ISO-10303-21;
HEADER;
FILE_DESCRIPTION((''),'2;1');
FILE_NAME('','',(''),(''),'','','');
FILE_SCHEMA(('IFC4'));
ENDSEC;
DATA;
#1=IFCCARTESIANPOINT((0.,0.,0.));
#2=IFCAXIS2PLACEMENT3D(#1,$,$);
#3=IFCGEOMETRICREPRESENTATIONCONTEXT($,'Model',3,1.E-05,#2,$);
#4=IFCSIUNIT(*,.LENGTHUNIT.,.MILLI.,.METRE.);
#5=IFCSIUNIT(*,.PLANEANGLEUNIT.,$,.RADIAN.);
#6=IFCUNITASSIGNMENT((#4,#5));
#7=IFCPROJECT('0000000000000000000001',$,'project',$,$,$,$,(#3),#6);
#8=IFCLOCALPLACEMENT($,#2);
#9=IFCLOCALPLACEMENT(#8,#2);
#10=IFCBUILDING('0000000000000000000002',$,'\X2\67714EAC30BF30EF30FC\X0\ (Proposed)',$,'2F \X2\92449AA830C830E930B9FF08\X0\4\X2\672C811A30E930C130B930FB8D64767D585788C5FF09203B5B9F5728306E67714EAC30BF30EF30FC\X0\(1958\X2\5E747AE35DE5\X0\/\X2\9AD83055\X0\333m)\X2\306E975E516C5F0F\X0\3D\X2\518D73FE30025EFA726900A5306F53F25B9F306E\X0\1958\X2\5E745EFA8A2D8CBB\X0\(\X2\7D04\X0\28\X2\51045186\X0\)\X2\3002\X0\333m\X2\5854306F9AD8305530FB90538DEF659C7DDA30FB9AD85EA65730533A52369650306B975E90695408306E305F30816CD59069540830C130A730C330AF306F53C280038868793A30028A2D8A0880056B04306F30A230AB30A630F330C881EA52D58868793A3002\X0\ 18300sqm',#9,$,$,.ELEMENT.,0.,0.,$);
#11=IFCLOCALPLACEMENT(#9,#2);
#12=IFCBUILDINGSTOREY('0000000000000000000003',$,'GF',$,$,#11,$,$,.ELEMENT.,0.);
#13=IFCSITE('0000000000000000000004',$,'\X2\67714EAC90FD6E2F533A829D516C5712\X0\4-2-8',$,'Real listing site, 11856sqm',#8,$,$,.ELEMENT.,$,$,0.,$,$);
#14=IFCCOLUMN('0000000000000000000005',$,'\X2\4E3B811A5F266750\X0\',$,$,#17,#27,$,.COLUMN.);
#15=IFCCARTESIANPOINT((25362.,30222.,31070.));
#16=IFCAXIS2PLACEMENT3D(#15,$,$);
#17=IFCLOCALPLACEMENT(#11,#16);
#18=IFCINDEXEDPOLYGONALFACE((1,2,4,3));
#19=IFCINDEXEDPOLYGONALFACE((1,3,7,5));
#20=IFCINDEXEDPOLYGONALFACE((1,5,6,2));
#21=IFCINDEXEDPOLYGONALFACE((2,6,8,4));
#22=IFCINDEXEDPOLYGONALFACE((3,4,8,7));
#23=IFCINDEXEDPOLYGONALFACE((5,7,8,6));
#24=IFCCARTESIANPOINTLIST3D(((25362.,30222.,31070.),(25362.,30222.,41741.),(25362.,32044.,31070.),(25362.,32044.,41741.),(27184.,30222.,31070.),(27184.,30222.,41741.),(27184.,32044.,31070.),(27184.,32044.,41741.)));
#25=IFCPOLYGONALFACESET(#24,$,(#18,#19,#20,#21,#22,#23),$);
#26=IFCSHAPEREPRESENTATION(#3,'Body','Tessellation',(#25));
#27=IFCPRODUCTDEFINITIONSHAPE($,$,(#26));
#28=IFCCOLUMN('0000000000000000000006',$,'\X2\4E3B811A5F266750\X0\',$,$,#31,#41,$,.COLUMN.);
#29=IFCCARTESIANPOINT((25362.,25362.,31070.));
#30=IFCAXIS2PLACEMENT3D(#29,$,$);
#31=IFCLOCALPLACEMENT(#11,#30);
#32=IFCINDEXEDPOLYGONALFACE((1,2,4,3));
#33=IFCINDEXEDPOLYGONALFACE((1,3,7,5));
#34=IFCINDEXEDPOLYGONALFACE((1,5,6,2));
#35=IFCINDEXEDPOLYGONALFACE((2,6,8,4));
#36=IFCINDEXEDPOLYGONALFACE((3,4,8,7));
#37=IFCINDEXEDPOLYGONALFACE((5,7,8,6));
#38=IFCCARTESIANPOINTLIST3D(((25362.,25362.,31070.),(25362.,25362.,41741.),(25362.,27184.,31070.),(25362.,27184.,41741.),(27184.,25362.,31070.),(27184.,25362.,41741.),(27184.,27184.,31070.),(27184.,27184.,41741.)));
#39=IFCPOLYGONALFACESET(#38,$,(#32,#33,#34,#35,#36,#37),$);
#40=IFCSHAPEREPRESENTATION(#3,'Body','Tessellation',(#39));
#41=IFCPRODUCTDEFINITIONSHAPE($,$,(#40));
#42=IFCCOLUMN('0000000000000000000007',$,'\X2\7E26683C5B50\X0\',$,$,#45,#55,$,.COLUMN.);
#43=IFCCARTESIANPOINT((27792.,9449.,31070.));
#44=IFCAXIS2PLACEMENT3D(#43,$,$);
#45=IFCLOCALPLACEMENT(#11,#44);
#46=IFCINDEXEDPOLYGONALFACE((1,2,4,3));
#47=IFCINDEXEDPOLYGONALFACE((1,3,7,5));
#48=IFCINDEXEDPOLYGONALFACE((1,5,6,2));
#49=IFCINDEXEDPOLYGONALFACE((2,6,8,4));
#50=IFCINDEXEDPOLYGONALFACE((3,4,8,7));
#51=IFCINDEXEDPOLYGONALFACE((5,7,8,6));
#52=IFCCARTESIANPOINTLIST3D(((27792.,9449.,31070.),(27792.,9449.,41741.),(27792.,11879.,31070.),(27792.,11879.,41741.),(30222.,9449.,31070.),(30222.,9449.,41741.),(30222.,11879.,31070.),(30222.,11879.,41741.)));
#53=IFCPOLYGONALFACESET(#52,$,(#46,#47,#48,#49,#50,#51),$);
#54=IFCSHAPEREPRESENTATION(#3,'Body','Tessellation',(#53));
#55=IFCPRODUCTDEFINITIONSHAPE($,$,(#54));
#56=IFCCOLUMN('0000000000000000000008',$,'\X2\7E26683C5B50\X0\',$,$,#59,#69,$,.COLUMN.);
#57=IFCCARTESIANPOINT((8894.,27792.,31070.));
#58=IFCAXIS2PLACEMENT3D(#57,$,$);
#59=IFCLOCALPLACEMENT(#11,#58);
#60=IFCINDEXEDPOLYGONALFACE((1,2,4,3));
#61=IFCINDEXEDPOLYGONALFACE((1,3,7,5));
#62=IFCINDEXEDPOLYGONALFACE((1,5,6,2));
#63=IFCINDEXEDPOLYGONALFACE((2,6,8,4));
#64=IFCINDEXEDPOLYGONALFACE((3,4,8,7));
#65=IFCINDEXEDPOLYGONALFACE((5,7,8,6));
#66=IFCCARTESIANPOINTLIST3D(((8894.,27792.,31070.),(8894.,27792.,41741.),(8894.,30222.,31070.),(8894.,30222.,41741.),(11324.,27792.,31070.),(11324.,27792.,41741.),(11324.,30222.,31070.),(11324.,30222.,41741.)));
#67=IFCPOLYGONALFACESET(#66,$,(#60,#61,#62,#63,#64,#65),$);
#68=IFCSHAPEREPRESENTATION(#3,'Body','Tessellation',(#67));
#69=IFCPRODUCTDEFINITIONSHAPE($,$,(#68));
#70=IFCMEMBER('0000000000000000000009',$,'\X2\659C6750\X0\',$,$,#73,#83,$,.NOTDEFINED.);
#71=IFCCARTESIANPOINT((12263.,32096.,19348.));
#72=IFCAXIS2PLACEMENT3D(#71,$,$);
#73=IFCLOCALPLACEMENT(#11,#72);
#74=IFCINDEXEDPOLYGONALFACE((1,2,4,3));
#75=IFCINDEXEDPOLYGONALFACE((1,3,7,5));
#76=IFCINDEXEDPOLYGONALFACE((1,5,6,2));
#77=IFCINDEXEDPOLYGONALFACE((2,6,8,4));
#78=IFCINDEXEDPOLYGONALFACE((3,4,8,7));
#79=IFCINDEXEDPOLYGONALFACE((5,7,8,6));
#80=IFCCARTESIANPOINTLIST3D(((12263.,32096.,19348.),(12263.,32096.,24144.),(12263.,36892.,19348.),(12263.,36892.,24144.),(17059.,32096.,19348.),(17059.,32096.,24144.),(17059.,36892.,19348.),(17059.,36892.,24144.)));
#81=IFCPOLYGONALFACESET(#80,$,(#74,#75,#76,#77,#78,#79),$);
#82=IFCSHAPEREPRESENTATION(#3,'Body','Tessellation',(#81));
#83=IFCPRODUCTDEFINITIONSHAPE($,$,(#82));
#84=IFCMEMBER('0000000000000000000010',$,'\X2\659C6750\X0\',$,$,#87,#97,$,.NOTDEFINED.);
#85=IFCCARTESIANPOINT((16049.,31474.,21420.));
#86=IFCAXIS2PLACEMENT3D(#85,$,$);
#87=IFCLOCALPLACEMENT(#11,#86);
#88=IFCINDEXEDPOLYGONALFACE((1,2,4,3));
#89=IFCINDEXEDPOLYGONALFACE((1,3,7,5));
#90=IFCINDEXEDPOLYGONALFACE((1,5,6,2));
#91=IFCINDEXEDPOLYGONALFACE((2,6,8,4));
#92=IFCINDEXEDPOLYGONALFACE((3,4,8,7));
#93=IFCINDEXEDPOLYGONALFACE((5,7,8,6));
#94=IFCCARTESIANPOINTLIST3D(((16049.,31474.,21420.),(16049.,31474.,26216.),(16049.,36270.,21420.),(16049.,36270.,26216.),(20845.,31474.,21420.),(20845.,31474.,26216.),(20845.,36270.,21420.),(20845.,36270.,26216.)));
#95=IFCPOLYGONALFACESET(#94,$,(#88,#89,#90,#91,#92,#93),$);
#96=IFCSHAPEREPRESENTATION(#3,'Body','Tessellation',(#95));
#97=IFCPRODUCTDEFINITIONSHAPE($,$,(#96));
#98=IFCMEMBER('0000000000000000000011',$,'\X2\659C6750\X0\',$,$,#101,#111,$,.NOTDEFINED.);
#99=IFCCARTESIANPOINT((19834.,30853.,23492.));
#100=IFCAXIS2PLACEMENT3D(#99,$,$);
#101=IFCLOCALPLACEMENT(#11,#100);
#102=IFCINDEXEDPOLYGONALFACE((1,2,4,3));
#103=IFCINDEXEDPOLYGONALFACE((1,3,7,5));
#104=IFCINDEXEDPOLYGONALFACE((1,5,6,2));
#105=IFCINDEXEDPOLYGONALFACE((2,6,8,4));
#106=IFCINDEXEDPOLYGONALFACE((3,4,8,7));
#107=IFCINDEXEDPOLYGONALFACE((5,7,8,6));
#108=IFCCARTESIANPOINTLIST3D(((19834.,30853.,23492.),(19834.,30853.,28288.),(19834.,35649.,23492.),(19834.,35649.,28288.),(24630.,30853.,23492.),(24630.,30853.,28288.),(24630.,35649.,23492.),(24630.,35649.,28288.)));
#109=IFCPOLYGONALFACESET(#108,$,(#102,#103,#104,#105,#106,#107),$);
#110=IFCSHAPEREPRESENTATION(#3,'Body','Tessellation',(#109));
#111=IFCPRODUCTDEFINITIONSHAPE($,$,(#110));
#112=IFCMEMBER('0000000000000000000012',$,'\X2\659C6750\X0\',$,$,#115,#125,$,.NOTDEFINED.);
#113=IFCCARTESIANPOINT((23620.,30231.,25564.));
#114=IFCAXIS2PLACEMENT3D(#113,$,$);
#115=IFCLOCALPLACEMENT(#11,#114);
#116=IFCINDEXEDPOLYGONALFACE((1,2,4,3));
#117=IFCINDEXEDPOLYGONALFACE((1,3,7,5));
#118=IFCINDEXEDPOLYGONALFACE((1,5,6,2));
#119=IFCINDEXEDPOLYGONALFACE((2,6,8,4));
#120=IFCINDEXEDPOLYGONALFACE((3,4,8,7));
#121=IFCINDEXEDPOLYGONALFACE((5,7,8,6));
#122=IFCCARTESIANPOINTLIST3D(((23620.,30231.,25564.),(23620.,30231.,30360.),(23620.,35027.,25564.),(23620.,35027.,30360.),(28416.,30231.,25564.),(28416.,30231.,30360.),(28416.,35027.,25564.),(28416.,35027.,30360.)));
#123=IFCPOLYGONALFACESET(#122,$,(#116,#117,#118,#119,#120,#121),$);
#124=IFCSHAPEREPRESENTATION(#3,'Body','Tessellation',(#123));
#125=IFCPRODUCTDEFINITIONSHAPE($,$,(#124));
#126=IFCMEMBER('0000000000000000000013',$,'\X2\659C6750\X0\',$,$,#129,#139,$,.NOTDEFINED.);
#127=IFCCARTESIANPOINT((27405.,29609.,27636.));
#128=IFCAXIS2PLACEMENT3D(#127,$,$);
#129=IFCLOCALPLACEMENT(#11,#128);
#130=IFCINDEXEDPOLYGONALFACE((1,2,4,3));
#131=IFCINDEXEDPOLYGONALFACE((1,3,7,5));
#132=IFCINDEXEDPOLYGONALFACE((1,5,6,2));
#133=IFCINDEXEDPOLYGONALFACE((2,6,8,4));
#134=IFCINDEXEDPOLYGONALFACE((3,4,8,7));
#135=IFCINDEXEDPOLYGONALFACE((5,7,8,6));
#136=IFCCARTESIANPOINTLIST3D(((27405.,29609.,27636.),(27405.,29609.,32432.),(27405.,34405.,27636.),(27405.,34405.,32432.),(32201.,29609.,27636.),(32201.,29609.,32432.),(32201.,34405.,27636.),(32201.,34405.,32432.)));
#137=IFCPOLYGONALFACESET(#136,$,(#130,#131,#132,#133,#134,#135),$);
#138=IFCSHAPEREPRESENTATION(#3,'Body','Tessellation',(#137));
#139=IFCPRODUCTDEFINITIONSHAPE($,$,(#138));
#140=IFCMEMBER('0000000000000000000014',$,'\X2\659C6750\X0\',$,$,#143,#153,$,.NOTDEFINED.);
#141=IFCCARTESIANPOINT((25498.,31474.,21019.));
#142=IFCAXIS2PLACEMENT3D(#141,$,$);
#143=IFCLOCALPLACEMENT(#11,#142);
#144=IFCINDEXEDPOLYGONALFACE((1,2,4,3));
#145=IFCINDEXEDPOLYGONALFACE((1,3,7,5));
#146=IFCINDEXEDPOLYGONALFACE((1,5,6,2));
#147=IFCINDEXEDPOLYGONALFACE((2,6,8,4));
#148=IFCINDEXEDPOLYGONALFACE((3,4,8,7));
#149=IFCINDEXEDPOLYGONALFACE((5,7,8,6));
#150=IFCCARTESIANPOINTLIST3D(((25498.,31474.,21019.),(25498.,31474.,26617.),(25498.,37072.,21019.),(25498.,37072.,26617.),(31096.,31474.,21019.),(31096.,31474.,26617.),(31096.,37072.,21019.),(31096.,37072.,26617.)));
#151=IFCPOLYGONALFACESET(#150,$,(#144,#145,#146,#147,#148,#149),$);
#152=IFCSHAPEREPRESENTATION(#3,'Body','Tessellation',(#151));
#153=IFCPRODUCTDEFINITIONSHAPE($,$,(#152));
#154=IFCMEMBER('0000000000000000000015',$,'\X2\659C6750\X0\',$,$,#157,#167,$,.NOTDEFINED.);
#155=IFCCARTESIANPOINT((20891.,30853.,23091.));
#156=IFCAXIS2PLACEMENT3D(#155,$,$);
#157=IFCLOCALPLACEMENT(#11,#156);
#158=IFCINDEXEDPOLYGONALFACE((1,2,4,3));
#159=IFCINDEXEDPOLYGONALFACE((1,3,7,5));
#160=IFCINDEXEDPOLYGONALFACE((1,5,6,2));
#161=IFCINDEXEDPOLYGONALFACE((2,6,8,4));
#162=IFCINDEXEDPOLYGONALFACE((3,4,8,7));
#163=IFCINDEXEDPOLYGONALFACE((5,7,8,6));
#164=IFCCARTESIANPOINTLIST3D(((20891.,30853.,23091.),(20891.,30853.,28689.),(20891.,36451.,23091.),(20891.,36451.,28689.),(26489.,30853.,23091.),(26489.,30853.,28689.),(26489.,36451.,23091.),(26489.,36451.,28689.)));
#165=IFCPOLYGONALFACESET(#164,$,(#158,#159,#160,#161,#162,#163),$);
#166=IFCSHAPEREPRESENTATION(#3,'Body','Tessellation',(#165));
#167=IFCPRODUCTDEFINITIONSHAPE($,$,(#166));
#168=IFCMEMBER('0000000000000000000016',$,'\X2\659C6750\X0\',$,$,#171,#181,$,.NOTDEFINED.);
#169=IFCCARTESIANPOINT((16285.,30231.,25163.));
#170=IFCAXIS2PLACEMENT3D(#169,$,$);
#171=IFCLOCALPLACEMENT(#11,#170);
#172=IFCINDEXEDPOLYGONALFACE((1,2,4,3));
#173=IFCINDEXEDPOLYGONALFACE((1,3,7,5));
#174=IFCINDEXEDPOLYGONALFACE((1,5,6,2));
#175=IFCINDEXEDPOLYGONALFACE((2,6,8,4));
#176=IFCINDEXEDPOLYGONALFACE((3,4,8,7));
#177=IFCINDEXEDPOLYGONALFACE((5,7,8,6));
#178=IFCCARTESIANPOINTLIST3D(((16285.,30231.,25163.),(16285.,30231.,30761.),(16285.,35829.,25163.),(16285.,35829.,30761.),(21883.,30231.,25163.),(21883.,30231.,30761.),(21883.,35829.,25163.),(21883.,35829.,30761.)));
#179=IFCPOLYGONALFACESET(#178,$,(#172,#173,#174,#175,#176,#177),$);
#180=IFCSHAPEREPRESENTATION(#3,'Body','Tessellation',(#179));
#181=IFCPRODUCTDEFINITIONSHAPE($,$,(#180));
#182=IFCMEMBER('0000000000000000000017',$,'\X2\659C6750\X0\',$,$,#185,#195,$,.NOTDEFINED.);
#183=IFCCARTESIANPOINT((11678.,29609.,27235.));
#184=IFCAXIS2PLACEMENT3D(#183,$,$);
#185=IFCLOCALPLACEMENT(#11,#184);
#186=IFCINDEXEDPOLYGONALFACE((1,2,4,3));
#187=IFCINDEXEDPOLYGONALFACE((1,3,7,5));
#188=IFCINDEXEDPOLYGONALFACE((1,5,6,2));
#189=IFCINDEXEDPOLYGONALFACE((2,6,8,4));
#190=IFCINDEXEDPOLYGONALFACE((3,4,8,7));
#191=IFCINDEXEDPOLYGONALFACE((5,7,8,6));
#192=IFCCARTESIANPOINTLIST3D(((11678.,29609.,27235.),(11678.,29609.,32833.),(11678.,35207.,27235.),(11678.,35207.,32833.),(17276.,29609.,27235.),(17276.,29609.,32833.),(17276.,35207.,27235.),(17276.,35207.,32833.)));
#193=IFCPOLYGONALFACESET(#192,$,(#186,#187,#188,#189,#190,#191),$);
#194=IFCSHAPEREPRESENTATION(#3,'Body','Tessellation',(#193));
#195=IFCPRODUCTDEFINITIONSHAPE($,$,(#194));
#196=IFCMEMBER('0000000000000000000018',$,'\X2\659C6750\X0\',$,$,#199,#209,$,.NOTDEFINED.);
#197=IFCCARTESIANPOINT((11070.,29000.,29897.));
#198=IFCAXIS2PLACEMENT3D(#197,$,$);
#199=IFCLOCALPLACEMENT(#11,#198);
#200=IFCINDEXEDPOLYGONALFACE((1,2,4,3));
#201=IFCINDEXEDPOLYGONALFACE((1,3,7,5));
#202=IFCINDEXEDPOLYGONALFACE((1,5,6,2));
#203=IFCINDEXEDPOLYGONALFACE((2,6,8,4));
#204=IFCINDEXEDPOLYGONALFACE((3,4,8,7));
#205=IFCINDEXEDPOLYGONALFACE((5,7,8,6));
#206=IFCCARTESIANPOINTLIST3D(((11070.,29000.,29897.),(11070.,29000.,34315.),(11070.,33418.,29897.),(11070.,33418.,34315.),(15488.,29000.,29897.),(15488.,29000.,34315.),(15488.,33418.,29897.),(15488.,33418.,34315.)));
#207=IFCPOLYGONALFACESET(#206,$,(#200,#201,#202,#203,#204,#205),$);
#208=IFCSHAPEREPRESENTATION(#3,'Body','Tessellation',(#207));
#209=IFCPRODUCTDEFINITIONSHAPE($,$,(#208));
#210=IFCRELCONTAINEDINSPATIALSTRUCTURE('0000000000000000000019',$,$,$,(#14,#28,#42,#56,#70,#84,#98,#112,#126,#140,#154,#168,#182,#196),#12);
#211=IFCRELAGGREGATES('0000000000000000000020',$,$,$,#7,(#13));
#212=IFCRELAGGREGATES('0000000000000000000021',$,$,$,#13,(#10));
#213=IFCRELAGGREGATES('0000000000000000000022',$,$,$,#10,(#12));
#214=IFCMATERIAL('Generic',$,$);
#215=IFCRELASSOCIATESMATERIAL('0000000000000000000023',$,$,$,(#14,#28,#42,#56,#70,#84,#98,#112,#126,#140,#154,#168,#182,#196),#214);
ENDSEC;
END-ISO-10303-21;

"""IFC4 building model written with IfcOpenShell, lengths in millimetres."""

from ifc_helpers import new_model, si_unit, frame, frame_2d, origin, place, context, project, spatial, rectangle, extrude, material, element, save


model = new_model("IFC4")

# Units and contexts
model_context = context("Model", 3, precision=1e-05, world=origin())
ifc_project = project(units=[si_unit("LENGTHUNIT", "METRE", prefix="MILLI"), si_unit("PLANEANGLEUNIT", "RADIAN")], contexts=[model_context])

# Site, building, storey
site_placement = place(None, origin())
site = spatial("IfcSite", under=ifc_project, at=site_placement, Name="東京都港区芝公園4-2-8", ObjectType="Real listing site, 11856sqm", CompositionType="ELEMENT", RefElevation=0.0)
building_placement = place(site_placement, origin())
building = spatial("IfcBuilding", under=site, at=building_placement, Name="東京タワー (Proposed)", ObjectType="2F 鉄骨トラス（4本脚ラチス・赤白塗装）※実在の東京タワー(1958年竣工/高さ333m)の非公式3D再現。建物¥は史実の1958年建設費(約28億円)。333m塔は高さ・道路斜線・高度地区制限に非適合のため法適合チェックは参考表示。設計者欄はアカウント自動表示。 18300sqm", CompositionType="ELEMENT", ElevationOfRefHeight=0.0, ElevationOfTerrain=0.0)
storey_placement = place(building_placement, origin())
storey = spatial("IfcBuildingStorey", under=building, at=storey_placement, Name="GF", CompositionType="ELEMENT", Elevation=0.0)

# Columns
ifc_material = material(Name="Generic")
column_1_placement = place(storey_placement, frame((25362.0, 30222.0, 31070.0)))
element("IfcColumn", 1, at=column_1_placement, inside=storey, material=ifc_material, Name="主脚弦材", PredefinedType="COLUMN", context=model_context, shape_type="SweptSolid", body=[
    extrude(rectangle(XDim=1822.0, YDim=1822.0, at=frame_2d((911.0, 911.0))), frame((25362.0, 30222.0, 31070.0)), (0.0, 0.0, 1.0), 10671.0),
])
column_2_placement = place(storey_placement, frame((25362.0, 25362.0, 31070.0)))
element("IfcColumn", 2, at=column_2_placement, inside=storey, material=ifc_material, Name="主脚弦材", PredefinedType="COLUMN", context=model_context, shape_type="SweptSolid", body=[
    extrude(rectangle(XDim=1822.0, YDim=1822.0, at=frame_2d((911.0, 911.0))), frame((25362.0, 25362.0, 31070.0)), (0.0, 0.0, 1.0), 10671.0),
])
column_3_placement = place(storey_placement, frame((27792.0, 9449.0, 31070.0)))
element("IfcColumn", 3, at=column_3_placement, inside=storey, material=ifc_material, Name="縦格子", PredefinedType="COLUMN", context=model_context, shape_type="SweptSolid", body=[
    extrude(rectangle(XDim=2430.0, YDim=2430.0, at=frame_2d((1215.0, 1215.0))), frame((27792.0, 9449.0, 31070.0)), (0.0, 0.0, 1.0), 10671.0),
])
column_4_placement = place(storey_placement, frame((8894.0, 27792.0, 31070.0)))
element("IfcColumn", 4, at=column_4_placement, inside=storey, material=ifc_material, Name="縦格子", PredefinedType="COLUMN", context=model_context, shape_type="SweptSolid", body=[
    extrude(rectangle(XDim=2430.0, YDim=2430.0, at=frame_2d((1215.0, 1215.0))), frame((8894.0, 27792.0, 31070.0)), (0.0, 0.0, 1.0), 10671.0),
])

# Members
member_1_placement = place(storey_placement, frame((12263.0, 32096.0, 19348.0)))
element("IfcMember", 5, at=member_1_placement, inside=storey, material=ifc_material, Name="斜材", PredefinedType="NOTDEFINED", context=model_context, shape_type="SweptSolid", body=[
    extrude(rectangle(XDim=4796.0, YDim=4796.0, at=frame_2d((2398.0, 2398.0))), frame((12263.0, 32096.0, 19348.0)), (0.0, 0.0, 1.0), 4796.0),
])
member_2_placement = place(storey_placement, frame((16049.0, 31474.0, 21420.0)))
element("IfcMember", 6, at=member_2_placement, inside=storey, material=ifc_material, Name="斜材", PredefinedType="NOTDEFINED", context=model_context, shape_type="SweptSolid", body=[
    extrude(rectangle(XDim=4796.0, YDim=4796.0, at=frame_2d((2398.0, 2398.0))), frame((16049.0, 31474.0, 21420.0)), (0.0, 0.0, 1.0), 4796.0),
])
member_3_placement = place(storey_placement, frame((19834.0, 30853.0, 23492.0)))
element("IfcMember", 7, at=member_3_placement, inside=storey, material=ifc_material, Name="斜材", PredefinedType="NOTDEFINED", context=model_context, shape_type="SweptSolid", body=[
    extrude(rectangle(XDim=4796.0, YDim=4796.0, at=frame_2d((2398.0, 2398.0))), frame((19834.0, 30853.0, 23492.0)), (0.0, 0.0, 1.0), 4796.0),
])
member_4_placement = place(storey_placement, frame((23620.0, 30231.0, 25564.0)))
element("IfcMember", 8, at=member_4_placement, inside=storey, material=ifc_material, Name="斜材", PredefinedType="NOTDEFINED", context=model_context, shape_type="SweptSolid", body=[
    extrude(rectangle(XDim=4796.0, YDim=4796.0, at=frame_2d((2398.0, 2398.0))), frame((23620.0, 30231.0, 25564.0)), (0.0, 0.0, 1.0), 4796.0),
])
member_5_placement = place(storey_placement, frame((27405.0, 29609.0, 27636.0)))
element("IfcMember", 9, at=member_5_placement, inside=storey, material=ifc_material, Name="斜材", PredefinedType="NOTDEFINED", context=model_context, shape_type="SweptSolid", body=[
    extrude(rectangle(XDim=4796.0, YDim=4796.0, at=frame_2d((2398.0, 2398.0))), frame((27405.0, 29609.0, 27636.0)), (0.0, 0.0, 1.0), 4796.0),
])
member_6_placement = place(storey_placement, frame((25498.0, 31474.0, 21019.0)))
element("IfcMember", 10, at=member_6_placement, inside=storey, material=ifc_material, Name="斜材", PredefinedType="NOTDEFINED", context=model_context, shape_type="SweptSolid", body=[
    extrude(rectangle(XDim=5598.0, YDim=5598.0, at=frame_2d((2799.0, 2799.0))), frame((25498.0, 31474.0, 21019.0)), (0.0, 0.0, 1.0), 5598.0),
])
member_7_placement = place(storey_placement, frame((20891.0, 30853.0, 23091.0)))
element("IfcMember", 11, at=member_7_placement, inside=storey, material=ifc_material, Name="斜材", PredefinedType="NOTDEFINED", context=model_context, shape_type="SweptSolid", body=[
    extrude(rectangle(XDim=5598.0, YDim=5598.0, at=frame_2d((2799.0, 2799.0))), frame((20891.0, 30853.0, 23091.0)), (0.0, 0.0, 1.0), 5598.0),
])
member_8_placement = place(storey_placement, frame((16285.0, 30231.0, 25163.0)))
element("IfcMember", 12, at=member_8_placement, inside=storey, material=ifc_material, Name="斜材", PredefinedType="NOTDEFINED", context=model_context, shape_type="SweptSolid", body=[
    extrude(rectangle(XDim=5598.0, YDim=5598.0, at=frame_2d((2799.0, 2799.0))), frame((16285.0, 30231.0, 25163.0)), (0.0, 0.0, 1.0), 5598.0),
])
member_9_placement = place(storey_placement, frame((11678.0, 29609.0, 27235.0)))
element("IfcMember", 13, at=member_9_placement, inside=storey, material=ifc_material, Name="斜材", PredefinedType="NOTDEFINED", context=model_context, shape_type="SweptSolid", body=[
    extrude(rectangle(XDim=5598.0, YDim=5598.0, at=frame_2d((2799.0, 2799.0))), frame((11678.0, 29609.0, 27235.0)), (0.0, 0.0, 1.0), 5598.0),
])
member_10_placement = place(storey_placement, frame((11070.0, 29000.0, 29897.0)))
element("IfcMember", 14, at=member_10_placement, inside=storey, material=ifc_material, Name="斜材", PredefinedType="NOTDEFINED", context=model_context, shape_type="SweptSolid", body=[
    extrude(rectangle(XDim=4418.0, YDim=4418.0, at=frame_2d((2209.0, 2209.0))), frame((11070.0, 29000.0, 29897.0)), (0.0, 0.0, 1.0), 4418.0),
])

save(model, "model.ifc")
